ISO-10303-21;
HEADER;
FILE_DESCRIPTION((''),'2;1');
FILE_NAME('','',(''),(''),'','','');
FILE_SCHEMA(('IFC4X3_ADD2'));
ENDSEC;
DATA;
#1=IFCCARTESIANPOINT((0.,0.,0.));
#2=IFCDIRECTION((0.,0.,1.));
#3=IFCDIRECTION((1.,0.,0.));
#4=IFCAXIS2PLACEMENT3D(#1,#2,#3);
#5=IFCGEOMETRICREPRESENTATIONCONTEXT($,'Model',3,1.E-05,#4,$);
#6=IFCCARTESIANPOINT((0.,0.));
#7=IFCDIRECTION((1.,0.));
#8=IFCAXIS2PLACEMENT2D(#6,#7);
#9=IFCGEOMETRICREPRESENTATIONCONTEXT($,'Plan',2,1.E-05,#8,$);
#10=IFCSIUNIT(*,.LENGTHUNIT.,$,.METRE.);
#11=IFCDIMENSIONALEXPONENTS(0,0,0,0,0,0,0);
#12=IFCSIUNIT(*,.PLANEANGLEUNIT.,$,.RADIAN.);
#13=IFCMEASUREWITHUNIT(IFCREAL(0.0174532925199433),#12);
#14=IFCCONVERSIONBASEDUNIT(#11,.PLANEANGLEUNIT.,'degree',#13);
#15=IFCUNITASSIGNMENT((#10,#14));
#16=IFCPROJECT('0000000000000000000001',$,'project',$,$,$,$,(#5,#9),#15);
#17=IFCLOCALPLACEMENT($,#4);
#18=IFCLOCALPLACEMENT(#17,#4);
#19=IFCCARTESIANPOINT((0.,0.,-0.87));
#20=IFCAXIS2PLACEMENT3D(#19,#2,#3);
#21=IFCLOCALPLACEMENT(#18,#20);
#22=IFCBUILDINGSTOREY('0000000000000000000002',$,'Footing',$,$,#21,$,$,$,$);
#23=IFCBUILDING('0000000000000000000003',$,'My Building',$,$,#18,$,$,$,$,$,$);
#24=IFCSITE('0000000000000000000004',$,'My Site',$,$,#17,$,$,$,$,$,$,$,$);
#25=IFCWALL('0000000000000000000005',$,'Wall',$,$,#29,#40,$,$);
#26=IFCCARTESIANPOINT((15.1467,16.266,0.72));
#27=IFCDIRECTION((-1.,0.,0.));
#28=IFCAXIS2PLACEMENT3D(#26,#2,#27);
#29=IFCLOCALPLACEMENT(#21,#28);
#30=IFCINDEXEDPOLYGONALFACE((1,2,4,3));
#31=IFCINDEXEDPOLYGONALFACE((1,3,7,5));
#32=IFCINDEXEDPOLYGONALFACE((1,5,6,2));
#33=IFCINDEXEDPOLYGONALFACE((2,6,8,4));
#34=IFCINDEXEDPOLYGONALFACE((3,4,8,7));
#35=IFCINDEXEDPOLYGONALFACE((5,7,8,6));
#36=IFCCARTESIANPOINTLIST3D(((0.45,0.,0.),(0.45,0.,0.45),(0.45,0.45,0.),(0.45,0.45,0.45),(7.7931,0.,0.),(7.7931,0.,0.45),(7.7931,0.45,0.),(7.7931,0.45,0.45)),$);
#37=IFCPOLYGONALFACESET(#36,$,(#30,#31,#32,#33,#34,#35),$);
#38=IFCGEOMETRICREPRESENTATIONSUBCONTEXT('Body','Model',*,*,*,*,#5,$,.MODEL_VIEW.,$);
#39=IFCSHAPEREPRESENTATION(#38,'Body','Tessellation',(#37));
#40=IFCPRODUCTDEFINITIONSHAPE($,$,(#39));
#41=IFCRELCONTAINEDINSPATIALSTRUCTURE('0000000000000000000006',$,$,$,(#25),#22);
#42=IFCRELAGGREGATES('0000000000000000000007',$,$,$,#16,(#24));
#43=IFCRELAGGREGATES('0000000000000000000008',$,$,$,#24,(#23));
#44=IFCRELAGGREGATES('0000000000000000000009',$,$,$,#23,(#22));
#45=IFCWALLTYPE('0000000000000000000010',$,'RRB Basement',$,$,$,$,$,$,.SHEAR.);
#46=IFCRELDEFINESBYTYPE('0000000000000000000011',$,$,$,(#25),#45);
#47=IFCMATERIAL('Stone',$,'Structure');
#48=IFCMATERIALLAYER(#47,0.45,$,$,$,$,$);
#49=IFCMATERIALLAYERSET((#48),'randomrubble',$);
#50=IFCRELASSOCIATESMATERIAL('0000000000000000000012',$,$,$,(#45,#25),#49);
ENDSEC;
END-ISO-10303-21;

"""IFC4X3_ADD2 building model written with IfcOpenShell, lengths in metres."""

from ifc_helpers import new_model, entity, si_unit, converted_unit, frame, origin_with_axes, origin_2d_with_axis, place, context, subcontext, project, spatial, line, indexed_curve, outline, extrude, material, layer, layer_set, layer_usage, type_object, element, save


model = new_model("IFC4X3_ADD2")

# Units and contexts
model_context = context("Model", 3, precision=1e-05, world=origin_with_axes())
plan_context = context("Plan", 2, precision=1e-05, world=origin_2d_with_axis())
body_context = subcontext(model_context, "Body", "Model", "MODEL_VIEW")
ifc_project = project(units=[si_unit("LENGTHUNIT", "METRE"), converted_unit("PLANEANGLEUNIT", "degree", entity("IfcReal", 0.0174532925199433), si_unit("PLANEANGLEUNIT", "RADIAN"), dimensions=[0, 0, 0, 0, 0, 0, 0])], contexts=[model_context, plan_context])

# Site, building, storey
site_placement = place(None, origin_with_axes())
site = spatial("IfcSite", under=ifc_project, at=site_placement, Name="My Site")
building_placement = place(site_placement, origin_with_axes())
building = spatial("IfcBuilding", under=site, at=building_placement, Name="My Building")
storey_placement = place(building_placement, frame((0.0, 0.0, -0.87), z_axis=(0.0, 0.0, 1.0), x_axis=(1.0, 0.0, 0.0)))
storey = spatial("IfcBuildingStorey", under=building, at=storey_placement, Name="Footing")

# Shared definitions
ifc_material_1 = material(Name="Stone", Category="Structure")

# Wall
ifc_layer_1 = layer(ifc_material_1, 0.45)
ifc_layer_set_1 = layer_set([ifc_layer_1], Name="randomrubble")
wall_type_1 = type_object("IfcWallType", Name="RRB Basement", PredefinedType="SHEAR", material=ifc_layer_set_1)
ifc_layer_usage_1 = layer_usage(ifc_layer_set_1, "AXIS2", "POSITIVE", 0.0)
wall_1_placement = place(storey_placement, frame((15.1467, 16.266, 0.72), z_axis=(0.0, 0.0, 1.0), x_axis=(-1.0, 0.0, 0.0)))
element("IfcWall", 1, at=wall_1_placement, inside=storey, type_object=wall_type_1, material=ifc_layer_usage_1, Name="Wall", context=body_context, shape_type="SweptSolid", body=[
    extrude(outline(indexed_curve([(0.45, 0.0), (0.45, 0.45), (7.7931, 0.45), (7.7931, 0.0)], segments=[line(1, 2, 3, 4, 1)])), origin_with_axes(), (0.0, 0.0, 1.0), 0.45),
])

save(model, "model.ifc")
